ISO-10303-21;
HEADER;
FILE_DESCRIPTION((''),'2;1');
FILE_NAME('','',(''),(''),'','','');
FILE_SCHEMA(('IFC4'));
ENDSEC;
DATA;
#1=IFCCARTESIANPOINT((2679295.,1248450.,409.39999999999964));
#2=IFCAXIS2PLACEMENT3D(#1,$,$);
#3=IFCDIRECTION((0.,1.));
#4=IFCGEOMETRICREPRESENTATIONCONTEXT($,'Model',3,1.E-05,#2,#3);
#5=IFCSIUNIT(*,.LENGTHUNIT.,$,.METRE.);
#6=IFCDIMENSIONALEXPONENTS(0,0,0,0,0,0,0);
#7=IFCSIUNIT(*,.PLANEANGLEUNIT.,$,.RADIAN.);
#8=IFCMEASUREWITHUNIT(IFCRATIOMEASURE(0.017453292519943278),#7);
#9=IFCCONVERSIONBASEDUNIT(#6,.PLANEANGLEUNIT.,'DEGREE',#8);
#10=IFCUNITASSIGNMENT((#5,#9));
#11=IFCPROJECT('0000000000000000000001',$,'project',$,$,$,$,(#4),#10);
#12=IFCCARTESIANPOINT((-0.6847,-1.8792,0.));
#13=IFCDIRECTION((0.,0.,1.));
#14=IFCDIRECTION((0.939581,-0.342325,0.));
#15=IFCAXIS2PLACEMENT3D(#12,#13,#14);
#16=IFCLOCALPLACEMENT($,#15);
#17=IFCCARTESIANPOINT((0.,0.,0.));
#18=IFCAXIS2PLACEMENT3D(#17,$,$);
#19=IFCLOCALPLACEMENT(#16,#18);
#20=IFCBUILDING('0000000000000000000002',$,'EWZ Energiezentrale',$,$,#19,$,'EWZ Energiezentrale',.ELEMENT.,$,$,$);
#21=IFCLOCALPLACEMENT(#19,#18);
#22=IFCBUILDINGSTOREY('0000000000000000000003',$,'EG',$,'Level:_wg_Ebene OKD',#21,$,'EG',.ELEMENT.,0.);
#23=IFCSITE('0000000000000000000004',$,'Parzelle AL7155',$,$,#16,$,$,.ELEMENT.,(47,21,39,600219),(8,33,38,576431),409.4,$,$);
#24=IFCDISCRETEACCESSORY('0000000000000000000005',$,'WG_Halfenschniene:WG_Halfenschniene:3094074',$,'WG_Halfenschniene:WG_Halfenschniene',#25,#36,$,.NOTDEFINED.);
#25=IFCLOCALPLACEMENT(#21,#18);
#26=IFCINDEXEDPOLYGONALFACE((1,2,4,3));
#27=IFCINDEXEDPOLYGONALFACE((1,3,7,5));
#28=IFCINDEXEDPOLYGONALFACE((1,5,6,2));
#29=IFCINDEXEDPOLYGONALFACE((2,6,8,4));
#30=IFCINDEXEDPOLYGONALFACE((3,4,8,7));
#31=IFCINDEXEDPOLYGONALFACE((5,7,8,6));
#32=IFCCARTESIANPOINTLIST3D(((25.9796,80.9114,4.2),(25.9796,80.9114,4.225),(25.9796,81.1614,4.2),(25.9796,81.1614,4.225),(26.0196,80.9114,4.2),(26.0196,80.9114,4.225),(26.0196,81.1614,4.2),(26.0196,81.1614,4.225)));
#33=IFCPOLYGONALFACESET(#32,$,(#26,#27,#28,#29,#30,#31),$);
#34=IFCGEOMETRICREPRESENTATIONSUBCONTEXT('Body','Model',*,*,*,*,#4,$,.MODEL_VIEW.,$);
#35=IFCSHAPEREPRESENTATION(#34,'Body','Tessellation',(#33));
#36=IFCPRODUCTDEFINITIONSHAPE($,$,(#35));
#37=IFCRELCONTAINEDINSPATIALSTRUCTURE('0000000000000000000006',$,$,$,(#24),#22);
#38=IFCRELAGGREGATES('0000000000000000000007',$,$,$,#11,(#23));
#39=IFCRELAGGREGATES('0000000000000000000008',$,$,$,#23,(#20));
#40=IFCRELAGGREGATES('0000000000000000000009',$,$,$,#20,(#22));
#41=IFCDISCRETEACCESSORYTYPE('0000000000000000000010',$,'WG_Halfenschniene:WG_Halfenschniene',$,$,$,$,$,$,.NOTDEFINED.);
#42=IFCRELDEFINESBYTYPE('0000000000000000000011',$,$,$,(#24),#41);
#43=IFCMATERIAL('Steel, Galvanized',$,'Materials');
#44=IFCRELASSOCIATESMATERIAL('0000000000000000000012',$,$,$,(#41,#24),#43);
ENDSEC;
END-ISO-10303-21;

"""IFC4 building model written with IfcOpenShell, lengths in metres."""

from ifc_helpers import new_model, entity, si_unit, converted_unit, direction, frame, origin, place, context, subcontext, project, spatial, indexed_curve, outline, extrude, source, transform, mapped, material, type_object, element, save


model = new_model("IFC4")

# Units and contexts
model_context = context("Model", 3, precision=1e-05, world=frame((2679295.0, 1248450.0, 409.39999999999964)), true_north=direction((0.0, 1.0)))
body_context = subcontext(model_context, "Body", "Model", "MODEL_VIEW")
ifc_project = project(units=[si_unit("LENGTHUNIT", "METRE"), converted_unit("PLANEANGLEUNIT", "DEGREE", entity("IfcRatioMeasure", 0.017453292519943278), si_unit("PLANEANGLEUNIT", "RADIAN"), dimensions=[0, 0, 0, 0, 0, 0, 0])], contexts=[model_context])

# Site, building, storey
site_placement = place(None, frame((-0.6847, -1.8792, 0.0), z_axis=(0.0, 0.0, 1.0), x_axis=(0.939581, -0.342325, 0.0)))
site = spatial("IfcSite", under=ifc_project, at=site_placement, Name="Parzelle AL7155", CompositionType="ELEMENT", RefLatitude=(47, 21, 39, 600219), RefLongitude=(8, 33, 38, 576431), RefElevation=409.4)
building_placement = place(site_placement, origin())
building = spatial("IfcBuilding", under=site, at=building_placement, Name="EWZ Energiezentrale", LongName="EWZ Energiezentrale", CompositionType="ELEMENT")
storey_placement = place(building_placement, origin())
storey = spatial("IfcBuildingStorey", under=building, at=storey_placement, Name="EG", ObjectType="Level:_wg_Ebene OKD", LongName="EG", CompositionType="ELEMENT", Elevation=0.0)

# Discrete accessory
ifc_material_1 = material(Name="Steel, Galvanized", Category="Materials")
discrete_accessory_type = type_object("IfcDiscreteAccessoryType", Name="WG_Halfenschniene:WG_Halfenschniene", PredefinedType="NOTDEFINED", material=ifc_material_1)
shared_shape = source(origin(), body_context, "Body", "SweptSolid", [
    extrude(outline(indexed_curve([(-0.125, -0.02), (0.125, -0.02), (0.125, 0.02), (-0.125, 0.02), (-0.125, -0.02)], self_intersect=False)), frame((0.125, 0.0, -0.0125)), (0.0, 0.0, 1.0), 0.025),
])
for number, where, z_axis, x_axis, name in (
    (1, (25.9996, 80.9114, 4.2125), (0.0, 0.0, -1.0), (0.0, 1.0, 0.0), "WG_Halfenschniene:WG_Halfenschniene:3094074"),
):
    element("IfcDiscreteAccessory", number, at=place(storey_placement, frame(where, z_axis=z_axis, x_axis=x_axis)), inside=storey, type_object=discrete_accessory_type, material=ifc_material_1, Name=name, ObjectType="WG_Halfenschniene:WG_Halfenschniene", PredefinedType="NOTDEFINED", context=body_context, shape_type="MappedRepresentation", body=[
        mapped(shared_shape, transform((0.0, 0.0, 0.0), scale=1.0)),
    ])

save(model, "model.ifc")
